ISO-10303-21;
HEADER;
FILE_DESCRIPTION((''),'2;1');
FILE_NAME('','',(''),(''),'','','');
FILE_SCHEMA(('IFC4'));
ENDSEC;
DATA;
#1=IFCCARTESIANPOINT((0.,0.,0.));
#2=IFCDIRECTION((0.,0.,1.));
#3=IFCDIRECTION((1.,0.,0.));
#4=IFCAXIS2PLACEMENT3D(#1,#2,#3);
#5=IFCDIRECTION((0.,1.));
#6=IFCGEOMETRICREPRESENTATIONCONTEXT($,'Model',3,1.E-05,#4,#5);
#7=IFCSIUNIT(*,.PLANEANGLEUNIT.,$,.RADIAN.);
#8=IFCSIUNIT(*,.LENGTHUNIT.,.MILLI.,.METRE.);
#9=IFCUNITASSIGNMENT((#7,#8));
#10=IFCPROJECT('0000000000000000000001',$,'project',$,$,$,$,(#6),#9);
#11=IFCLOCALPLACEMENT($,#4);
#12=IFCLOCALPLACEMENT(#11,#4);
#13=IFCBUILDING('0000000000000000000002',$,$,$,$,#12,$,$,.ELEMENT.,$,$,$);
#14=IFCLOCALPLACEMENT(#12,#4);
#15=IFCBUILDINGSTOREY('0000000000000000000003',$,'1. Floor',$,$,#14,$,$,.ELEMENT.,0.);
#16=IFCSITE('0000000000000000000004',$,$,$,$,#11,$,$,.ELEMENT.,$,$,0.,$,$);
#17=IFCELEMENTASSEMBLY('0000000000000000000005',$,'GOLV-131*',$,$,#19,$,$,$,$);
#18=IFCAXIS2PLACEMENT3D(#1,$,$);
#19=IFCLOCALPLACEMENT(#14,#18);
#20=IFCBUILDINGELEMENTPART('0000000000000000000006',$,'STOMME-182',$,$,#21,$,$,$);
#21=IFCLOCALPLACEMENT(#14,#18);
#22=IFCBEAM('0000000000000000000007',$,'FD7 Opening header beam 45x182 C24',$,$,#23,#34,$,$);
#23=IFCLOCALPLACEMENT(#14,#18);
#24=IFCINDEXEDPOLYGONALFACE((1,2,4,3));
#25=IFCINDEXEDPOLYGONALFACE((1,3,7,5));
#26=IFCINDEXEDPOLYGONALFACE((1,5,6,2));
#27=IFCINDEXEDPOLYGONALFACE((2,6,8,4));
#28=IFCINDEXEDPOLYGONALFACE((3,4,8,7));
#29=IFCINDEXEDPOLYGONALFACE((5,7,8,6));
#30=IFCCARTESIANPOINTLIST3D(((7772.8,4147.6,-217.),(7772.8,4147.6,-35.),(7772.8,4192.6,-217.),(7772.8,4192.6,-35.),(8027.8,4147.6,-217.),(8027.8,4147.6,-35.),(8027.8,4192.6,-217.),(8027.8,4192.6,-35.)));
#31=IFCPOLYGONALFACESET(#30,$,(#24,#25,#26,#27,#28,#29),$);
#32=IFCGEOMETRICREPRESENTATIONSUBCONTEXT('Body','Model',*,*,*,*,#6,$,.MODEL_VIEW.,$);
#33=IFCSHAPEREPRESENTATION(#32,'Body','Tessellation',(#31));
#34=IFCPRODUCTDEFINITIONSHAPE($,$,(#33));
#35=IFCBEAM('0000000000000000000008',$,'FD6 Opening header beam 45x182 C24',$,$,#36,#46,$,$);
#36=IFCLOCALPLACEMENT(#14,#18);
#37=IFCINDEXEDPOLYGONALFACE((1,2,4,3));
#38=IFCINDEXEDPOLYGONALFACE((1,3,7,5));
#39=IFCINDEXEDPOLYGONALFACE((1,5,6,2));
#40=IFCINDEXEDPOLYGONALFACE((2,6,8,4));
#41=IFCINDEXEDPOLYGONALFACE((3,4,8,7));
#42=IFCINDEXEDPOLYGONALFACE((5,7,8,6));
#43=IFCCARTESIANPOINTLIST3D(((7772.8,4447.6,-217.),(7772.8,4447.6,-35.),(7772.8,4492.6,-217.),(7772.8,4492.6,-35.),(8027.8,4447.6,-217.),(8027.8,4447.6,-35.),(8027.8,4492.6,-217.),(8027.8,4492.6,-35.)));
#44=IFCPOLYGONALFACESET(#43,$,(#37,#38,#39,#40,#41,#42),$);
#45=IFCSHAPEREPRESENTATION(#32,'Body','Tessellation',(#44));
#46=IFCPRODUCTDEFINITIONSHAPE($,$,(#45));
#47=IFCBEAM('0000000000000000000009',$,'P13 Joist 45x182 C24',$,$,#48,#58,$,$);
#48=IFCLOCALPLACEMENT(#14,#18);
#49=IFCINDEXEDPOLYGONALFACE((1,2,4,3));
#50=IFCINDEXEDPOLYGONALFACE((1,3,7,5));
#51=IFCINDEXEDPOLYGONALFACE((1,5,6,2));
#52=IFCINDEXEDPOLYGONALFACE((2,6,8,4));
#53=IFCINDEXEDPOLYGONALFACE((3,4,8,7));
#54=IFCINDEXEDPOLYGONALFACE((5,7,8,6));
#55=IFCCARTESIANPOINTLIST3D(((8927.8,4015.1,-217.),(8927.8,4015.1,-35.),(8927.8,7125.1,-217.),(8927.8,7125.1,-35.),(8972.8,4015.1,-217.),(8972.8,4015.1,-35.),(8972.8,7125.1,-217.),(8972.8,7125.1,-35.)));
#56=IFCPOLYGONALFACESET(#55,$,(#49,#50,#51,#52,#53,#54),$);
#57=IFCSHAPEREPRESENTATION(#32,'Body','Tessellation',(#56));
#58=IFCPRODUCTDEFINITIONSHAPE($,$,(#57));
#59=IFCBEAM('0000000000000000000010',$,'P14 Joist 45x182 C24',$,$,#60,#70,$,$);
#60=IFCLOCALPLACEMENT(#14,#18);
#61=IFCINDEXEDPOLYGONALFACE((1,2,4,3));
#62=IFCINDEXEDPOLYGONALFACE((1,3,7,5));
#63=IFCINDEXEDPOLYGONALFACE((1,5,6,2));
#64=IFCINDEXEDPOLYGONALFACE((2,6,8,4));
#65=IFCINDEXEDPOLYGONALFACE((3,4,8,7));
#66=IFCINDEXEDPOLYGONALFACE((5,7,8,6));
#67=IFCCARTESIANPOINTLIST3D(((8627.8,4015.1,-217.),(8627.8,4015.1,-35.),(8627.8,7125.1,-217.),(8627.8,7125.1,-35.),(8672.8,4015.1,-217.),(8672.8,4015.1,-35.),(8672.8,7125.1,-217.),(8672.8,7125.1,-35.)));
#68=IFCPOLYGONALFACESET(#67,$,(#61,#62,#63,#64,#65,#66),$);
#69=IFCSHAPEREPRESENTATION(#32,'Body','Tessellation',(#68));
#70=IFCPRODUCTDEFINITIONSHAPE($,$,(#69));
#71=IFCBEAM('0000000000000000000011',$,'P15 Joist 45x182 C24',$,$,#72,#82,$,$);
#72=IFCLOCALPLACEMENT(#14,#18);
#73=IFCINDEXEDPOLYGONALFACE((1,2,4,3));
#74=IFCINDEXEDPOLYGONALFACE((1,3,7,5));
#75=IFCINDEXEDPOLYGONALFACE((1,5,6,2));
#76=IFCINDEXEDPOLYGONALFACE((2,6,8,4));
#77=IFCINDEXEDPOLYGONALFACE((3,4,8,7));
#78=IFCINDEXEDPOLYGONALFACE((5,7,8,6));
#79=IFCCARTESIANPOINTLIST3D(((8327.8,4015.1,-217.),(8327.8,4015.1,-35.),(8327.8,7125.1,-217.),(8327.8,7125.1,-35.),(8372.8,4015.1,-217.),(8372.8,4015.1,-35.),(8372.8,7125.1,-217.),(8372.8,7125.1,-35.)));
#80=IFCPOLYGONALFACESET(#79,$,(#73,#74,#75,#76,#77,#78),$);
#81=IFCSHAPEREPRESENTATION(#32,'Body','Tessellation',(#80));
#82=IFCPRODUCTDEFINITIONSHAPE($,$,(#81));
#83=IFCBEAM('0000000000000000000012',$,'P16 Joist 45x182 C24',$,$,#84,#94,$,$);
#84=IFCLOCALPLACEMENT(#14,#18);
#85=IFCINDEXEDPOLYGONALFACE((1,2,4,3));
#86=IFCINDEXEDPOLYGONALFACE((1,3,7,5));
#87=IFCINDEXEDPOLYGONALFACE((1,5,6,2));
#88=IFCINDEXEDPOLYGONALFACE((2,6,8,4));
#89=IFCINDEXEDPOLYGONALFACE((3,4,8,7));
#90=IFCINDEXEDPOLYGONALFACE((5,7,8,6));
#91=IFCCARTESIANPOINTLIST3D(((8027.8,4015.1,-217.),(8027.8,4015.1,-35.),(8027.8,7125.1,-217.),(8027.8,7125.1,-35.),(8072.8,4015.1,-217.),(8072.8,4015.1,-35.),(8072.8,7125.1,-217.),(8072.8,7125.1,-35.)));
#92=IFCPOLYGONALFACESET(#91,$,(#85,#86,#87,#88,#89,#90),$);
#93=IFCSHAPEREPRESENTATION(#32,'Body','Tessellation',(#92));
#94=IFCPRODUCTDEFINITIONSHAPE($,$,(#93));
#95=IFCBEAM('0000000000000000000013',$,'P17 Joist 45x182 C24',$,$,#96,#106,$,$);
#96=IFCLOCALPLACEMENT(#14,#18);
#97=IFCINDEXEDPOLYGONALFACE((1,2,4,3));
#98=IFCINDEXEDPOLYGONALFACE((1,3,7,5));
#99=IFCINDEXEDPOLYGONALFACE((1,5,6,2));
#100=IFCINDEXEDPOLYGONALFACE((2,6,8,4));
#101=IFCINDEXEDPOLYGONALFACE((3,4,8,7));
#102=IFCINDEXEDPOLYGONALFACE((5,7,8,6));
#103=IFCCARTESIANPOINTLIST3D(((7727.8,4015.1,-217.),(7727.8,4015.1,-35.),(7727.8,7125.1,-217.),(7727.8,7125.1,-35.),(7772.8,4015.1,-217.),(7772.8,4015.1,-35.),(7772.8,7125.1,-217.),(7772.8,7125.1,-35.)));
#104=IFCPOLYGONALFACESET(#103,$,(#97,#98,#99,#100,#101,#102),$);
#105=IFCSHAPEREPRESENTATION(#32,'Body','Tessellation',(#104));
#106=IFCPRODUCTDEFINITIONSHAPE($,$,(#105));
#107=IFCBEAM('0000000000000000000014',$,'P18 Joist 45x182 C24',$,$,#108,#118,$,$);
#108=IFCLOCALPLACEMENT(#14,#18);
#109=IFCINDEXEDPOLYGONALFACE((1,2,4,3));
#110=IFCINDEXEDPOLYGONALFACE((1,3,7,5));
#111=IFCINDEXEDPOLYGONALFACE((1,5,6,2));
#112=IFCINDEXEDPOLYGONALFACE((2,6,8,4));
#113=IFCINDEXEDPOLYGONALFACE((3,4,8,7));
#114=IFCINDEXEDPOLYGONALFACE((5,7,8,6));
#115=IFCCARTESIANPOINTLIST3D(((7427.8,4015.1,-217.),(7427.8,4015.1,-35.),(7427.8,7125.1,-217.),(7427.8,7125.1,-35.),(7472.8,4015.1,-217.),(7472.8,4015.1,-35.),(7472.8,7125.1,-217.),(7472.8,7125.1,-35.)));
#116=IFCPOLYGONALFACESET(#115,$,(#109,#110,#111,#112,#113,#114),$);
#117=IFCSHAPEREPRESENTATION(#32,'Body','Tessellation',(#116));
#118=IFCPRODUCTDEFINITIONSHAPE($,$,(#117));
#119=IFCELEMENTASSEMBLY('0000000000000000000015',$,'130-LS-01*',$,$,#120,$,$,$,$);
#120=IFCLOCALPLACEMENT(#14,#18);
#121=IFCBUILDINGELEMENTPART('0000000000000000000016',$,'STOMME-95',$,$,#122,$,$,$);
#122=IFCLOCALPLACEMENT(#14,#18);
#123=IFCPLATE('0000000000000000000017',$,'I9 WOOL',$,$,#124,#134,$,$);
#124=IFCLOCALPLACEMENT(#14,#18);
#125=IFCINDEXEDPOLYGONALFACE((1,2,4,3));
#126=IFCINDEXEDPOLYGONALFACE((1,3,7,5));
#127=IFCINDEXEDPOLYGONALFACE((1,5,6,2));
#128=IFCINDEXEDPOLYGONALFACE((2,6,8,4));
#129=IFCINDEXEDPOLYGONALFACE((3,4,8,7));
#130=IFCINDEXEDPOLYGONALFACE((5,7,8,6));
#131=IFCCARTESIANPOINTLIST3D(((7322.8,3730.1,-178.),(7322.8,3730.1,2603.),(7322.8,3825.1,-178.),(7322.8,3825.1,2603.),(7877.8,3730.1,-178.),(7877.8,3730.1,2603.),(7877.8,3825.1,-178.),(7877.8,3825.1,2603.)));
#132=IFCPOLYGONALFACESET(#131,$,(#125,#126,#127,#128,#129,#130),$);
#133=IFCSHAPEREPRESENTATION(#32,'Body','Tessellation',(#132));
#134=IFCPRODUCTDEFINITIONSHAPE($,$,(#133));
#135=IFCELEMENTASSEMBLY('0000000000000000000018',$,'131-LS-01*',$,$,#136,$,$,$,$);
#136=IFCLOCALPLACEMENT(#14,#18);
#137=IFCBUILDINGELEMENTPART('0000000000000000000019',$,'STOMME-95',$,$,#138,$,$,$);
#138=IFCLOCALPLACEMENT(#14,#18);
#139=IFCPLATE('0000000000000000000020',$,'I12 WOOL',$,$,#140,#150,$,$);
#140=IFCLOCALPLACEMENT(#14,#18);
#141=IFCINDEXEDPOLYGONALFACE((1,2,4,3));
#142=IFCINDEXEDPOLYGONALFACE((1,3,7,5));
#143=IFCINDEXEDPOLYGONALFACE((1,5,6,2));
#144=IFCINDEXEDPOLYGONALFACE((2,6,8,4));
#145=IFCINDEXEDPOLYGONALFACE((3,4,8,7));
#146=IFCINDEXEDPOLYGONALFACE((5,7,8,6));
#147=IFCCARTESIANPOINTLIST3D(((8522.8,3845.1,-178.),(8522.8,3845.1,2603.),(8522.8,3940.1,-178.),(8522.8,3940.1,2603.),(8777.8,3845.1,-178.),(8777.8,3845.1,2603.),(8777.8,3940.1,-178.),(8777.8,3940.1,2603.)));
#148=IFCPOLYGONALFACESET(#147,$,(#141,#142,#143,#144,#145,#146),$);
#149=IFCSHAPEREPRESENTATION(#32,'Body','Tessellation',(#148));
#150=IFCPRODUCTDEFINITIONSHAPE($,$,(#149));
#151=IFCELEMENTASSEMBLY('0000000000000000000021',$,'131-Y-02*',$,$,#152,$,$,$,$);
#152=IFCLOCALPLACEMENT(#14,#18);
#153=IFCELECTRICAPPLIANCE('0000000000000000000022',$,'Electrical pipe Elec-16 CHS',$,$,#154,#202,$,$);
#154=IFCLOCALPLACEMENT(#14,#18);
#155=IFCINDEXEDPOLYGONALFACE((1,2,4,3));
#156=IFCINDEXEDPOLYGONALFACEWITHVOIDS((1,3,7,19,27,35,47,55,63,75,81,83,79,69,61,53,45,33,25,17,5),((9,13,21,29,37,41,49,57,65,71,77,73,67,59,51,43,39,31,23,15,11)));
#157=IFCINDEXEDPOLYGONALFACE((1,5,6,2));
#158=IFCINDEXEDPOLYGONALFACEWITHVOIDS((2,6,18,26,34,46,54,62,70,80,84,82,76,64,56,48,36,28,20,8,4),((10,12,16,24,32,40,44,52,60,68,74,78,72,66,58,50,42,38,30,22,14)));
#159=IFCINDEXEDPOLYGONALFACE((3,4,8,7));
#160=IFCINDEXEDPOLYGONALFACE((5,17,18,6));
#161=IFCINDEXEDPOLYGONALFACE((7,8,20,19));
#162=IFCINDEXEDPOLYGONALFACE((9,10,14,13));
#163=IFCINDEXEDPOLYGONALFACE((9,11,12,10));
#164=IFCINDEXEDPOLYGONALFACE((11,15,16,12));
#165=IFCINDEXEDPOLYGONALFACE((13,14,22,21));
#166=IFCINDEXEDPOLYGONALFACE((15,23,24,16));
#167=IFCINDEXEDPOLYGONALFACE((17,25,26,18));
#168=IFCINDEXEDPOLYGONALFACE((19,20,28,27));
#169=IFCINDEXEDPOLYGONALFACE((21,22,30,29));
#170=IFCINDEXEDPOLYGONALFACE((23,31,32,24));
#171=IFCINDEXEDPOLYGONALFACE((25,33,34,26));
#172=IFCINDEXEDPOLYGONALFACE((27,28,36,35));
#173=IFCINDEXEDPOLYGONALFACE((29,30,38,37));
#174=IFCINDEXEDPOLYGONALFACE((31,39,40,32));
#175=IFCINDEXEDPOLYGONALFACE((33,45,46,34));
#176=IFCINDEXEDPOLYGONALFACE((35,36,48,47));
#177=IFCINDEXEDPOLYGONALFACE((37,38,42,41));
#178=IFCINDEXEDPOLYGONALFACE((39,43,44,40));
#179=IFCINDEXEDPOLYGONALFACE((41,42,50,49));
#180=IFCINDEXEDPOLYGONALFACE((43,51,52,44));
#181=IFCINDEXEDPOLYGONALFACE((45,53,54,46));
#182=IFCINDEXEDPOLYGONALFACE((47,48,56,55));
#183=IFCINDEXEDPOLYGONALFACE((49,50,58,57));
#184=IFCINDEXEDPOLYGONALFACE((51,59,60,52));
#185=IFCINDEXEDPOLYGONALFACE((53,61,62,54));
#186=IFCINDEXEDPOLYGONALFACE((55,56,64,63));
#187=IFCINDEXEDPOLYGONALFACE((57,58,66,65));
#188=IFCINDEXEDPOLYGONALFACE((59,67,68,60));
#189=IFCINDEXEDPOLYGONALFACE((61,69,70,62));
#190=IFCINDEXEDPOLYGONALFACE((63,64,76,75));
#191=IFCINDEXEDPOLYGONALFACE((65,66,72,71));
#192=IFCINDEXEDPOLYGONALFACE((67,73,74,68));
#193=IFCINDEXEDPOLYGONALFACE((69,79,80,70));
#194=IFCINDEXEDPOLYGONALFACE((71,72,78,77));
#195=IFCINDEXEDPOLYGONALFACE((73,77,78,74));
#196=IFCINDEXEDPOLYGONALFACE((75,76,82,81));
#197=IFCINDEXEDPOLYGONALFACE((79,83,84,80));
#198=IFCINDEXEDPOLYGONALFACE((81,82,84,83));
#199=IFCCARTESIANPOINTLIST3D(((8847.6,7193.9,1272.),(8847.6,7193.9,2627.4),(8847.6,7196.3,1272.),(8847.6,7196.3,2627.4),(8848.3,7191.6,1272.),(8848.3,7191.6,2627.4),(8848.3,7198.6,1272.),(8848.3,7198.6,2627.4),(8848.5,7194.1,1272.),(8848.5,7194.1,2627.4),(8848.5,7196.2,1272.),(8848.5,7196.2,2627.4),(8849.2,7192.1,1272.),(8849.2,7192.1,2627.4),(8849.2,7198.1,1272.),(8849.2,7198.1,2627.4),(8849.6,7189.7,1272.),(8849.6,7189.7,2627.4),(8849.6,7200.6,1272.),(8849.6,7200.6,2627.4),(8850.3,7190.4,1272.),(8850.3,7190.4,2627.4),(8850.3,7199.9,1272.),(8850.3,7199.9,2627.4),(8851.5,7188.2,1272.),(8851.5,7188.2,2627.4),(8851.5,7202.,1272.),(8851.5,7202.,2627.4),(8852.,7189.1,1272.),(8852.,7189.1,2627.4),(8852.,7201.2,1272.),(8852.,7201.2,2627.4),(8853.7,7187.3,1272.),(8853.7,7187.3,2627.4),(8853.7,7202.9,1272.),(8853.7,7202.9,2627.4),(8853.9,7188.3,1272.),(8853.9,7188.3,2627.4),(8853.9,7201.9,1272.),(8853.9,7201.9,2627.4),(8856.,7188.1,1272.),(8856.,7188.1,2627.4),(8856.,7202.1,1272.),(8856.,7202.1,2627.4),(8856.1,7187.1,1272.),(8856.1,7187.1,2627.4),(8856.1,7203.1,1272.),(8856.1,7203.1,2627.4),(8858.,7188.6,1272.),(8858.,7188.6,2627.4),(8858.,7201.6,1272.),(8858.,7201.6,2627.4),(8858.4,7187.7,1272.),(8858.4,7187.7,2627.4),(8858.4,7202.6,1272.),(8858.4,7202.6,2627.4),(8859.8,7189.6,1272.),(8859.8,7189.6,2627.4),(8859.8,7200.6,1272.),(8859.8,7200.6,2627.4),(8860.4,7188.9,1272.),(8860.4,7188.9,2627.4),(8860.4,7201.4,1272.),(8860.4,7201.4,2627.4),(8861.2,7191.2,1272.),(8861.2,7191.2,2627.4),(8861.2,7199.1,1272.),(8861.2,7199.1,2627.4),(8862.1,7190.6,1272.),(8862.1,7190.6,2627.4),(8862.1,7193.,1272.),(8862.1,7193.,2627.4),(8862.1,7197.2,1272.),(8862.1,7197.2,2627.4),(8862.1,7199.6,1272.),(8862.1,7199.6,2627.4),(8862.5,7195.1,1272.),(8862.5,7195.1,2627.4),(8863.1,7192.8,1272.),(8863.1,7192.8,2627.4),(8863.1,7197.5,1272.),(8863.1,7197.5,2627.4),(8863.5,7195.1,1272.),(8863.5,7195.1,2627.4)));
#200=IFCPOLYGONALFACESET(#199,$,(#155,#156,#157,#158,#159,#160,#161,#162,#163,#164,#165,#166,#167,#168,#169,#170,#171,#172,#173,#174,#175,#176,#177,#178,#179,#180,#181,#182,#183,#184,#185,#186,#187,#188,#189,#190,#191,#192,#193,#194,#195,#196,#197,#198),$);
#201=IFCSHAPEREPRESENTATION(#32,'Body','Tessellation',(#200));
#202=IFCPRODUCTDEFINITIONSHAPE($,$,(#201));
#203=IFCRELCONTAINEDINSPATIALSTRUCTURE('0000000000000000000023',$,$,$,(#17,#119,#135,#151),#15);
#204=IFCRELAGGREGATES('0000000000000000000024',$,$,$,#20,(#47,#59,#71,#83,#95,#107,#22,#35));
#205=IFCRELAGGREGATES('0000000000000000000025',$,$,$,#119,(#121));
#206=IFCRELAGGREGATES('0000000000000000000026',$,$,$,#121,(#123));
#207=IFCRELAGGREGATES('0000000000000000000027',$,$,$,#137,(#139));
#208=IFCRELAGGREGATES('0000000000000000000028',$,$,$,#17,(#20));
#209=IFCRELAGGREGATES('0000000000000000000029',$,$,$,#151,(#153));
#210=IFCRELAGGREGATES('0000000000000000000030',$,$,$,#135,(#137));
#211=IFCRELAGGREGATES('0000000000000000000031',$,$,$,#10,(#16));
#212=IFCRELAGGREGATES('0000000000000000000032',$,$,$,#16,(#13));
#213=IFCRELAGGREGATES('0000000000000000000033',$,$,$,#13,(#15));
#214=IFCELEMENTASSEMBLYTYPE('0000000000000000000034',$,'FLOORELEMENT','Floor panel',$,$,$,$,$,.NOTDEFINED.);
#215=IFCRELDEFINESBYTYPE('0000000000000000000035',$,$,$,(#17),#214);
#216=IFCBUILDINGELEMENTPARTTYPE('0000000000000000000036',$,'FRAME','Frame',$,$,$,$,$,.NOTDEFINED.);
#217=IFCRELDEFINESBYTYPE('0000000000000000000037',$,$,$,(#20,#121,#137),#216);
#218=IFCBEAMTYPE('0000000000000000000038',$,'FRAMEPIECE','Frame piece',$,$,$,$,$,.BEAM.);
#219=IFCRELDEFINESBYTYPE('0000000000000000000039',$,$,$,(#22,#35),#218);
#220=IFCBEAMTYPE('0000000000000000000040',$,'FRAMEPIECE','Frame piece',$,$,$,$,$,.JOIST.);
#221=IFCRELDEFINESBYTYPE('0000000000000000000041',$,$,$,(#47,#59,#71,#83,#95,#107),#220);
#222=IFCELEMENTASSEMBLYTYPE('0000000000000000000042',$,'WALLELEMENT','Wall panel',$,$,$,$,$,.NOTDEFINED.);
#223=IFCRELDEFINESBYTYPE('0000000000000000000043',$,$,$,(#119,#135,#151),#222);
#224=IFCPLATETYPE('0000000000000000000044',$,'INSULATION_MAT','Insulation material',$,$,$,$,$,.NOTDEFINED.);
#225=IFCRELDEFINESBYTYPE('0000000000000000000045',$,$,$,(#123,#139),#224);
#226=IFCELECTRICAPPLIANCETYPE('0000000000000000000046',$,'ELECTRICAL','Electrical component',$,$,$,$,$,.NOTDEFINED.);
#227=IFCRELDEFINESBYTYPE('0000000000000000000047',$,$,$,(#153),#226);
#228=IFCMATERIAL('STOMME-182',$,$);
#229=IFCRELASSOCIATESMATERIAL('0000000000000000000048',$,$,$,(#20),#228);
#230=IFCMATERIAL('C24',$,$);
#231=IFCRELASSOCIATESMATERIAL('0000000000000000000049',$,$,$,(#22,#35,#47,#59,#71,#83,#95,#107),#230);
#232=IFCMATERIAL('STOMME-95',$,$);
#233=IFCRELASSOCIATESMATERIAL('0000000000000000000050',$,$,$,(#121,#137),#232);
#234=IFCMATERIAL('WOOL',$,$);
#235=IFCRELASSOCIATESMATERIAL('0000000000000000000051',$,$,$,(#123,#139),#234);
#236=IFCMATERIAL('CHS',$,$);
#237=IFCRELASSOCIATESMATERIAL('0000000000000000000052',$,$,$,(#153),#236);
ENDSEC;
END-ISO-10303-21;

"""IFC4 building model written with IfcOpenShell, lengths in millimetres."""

from ifc_helpers import new_model, si_unit, direction, frame, origin_with_axes, origin_2d_with_axis, place, context, subcontext, project, spatial, rectangle, hollow_circle, extrude, material, type_object, element, aggregate, save


model = new_model("IFC4")

# Units and contexts
model_context = context("Model", 3, precision=1e-05, world=origin_with_axes(), true_north=direction((0.0, 1.0)))
body_context = subcontext(model_context, "Body", "Model", "MODEL_VIEW")
ifc_project = project(units=[si_unit("PLANEANGLEUNIT", "RADIAN"), si_unit("LENGTHUNIT", "METRE", prefix="MILLI")], contexts=[model_context])

# Site, building, storey
site_placement = place(None, origin_with_axes())
site = spatial("IfcSite", under=ifc_project, at=site_placement, CompositionType="ELEMENT", RefElevation=0.0)
building_placement = place(site_placement, origin_with_axes())
building = spatial("IfcBuilding", under=site, at=building_placement, CompositionType="ELEMENT")
storey_placement = place(building_placement, origin_with_axes())
storey = spatial("IfcBuildingStorey", under=building, at=storey_placement, Name="1. Floor", CompositionType="ELEMENT", Elevation=0.0)

# Element assembly, building element part, beams
element_assembly_type_1 = type_object("IfcElementAssemblyType", Name="FLOORELEMENT", Description="Floor panel", PredefinedType="NOTDEFINED")
assembly_1_placement = place(storey_placement, origin_with_axes())
assembly_1 = element("IfcElementAssembly", 1, at=assembly_1_placement, inside=storey, type_object=element_assembly_type_1, Name="GOLV-131*")
ifc_material_1 = material(Name="STOMME-182")
building_element_part_type_1 = type_object("IfcBuildingElementPartType", Name="FRAME", Description="Frame", PredefinedType="NOTDEFINED")
building_element_part_1_placement = place(storey_placement, origin_with_axes())
building_element_part_1 = element("IfcBuildingElementPart", 2, at=building_element_part_1_placement, type_object=building_element_part_type_1, material=ifc_material_1, Name="STOMME-182")
ifc_material_2 = material(Name="C24")
beam_type_1 = type_object("IfcBeamType", Name="FRAMEPIECE", Description="Frame piece", PredefinedType="BEAM")
beam_1_placement = place(storey_placement, frame((7772.8, 4170.1, -126.0), z_axis=(1.0, 0.0, 0.0), x_axis=(0.0, 1.0, 0.0)))
beam_1 = element("IfcBeam", 3, at=beam_1_placement, type_object=beam_type_1, material=ifc_material_2, Name="FD7 Opening header beam 45x182 C24", context=body_context, shape_type="SweptSolid", body=[
    extrude(rectangle(XDim=45.0, YDim=182.0, at=origin_2d_with_axis()), origin_with_axes(), (0.0, 0.0, 1.0), 255.0),
])
beam_2_placement = place(storey_placement, frame((8027.8, 4470.1, -126.0), z_axis=(-1.0, 0.0, 0.0), x_axis=(0.0, -1.0, 0.0)))
beam_2 = element("IfcBeam", 4, at=beam_2_placement, type_object=beam_type_1, material=ifc_material_2, Name="FD6 Opening header beam 45x182 C24", context=body_context, shape_type="SweptSolid", body=[
    extrude(rectangle(XDim=45.0, YDim=182.0, at=origin_2d_with_axis()), origin_with_axes(), (0.0, 0.0, 1.0), 255.0),
])
beam_type_2 = type_object("IfcBeamType", Name="FRAMEPIECE", Description="Frame piece", PredefinedType="JOIST")
beam_3_placement = place(storey_placement, frame((8950.3, 4015.1, -126.0), z_axis=(0.0, 1.0, 0.0), x_axis=(-1.0, 0.0, 0.0)))
beam_3 = element("IfcBeam", 5, at=beam_3_placement, type_object=beam_type_2, material=ifc_material_2, Name="P13 Joist 45x182 C24", context=body_context, shape_type="SweptSolid", body=[
    extrude(rectangle(XDim=45.0, YDim=182.0, at=origin_2d_with_axis()), origin_with_axes(), (0.0, 0.0, 1.0), 3110.0),
])
beam_4_placement = place(storey_placement, frame((8650.3, 4015.1, -126.0), z_axis=(0.0, 1.0, 0.0), x_axis=(-1.0, 0.0, 0.0)))
beam_4 = element("IfcBeam", 6, at=beam_4_placement, type_object=beam_type_2, material=ifc_material_2, Name="P14 Joist 45x182 C24", context=body_context, shape_type="SweptSolid", body=[
    extrude(rectangle(XDim=45.0, YDim=182.0, at=origin_2d_with_axis()), origin_with_axes(), (0.0, 0.0, 1.0), 3110.0),
])
beam_5_placement = place(storey_placement, frame((8350.3, 4015.1, -126.0), z_axis=(0.0, 1.0, 0.0), x_axis=(-1.0, 0.0, 0.0)))
beam_5 = element("IfcBeam", 7, at=beam_5_placement, type_object=beam_type_2, material=ifc_material_2, Name="P15 Joist 45x182 C24", context=body_context, shape_type="SweptSolid", body=[
    extrude(rectangle(XDim=45.0, YDim=182.0, at=origin_2d_with_axis()), origin_with_axes(), (0.0, 0.0, 1.0), 3110.0),
])
beam_6_placement = place(storey_placement, frame((8050.3, 4015.1, -126.0), z_axis=(0.0, 1.0, 0.0), x_axis=(-1.0, 0.0, 0.0)))
beam_6 = element("IfcBeam", 8, at=beam_6_placement, type_object=beam_type_2, material=ifc_material_2, Name="P16 Joist 45x182 C24", context=body_context, shape_type="SweptSolid", body=[
    extrude(rectangle(XDim=45.0, YDim=182.0, at=origin_2d_with_axis()), origin_with_axes(), (0.0, 0.0, 1.0), 3110.0),
])
beam_7_placement = place(storey_placement, frame((7750.3, 4015.1, -126.0), z_axis=(0.0, 1.0, 0.0), x_axis=(-1.0, 0.0, 0.0)))
beam_7 = element("IfcBeam", 9, at=beam_7_placement, type_object=beam_type_2, material=ifc_material_2, Name="P17 Joist 45x182 C24", context=body_context, shape_type="SweptSolid", body=[
    extrude(rectangle(XDim=45.0, YDim=182.0, at=origin_2d_with_axis()), origin_with_axes(), (0.0, 0.0, 1.0), 3110.0),
])
beam_8_placement = place(storey_placement, frame((7450.3, 4015.1, -126.0), z_axis=(0.0, 1.0, 0.0), x_axis=(-1.0, 0.0, 0.0)))
beam_8 = element("IfcBeam", 10, at=beam_8_placement, type_object=beam_type_2, material=ifc_material_2, Name="P18 Joist 45x182 C24", context=body_context, shape_type="SweptSolid", body=[
    extrude(rectangle(XDim=45.0, YDim=182.0, at=origin_2d_with_axis()), origin_with_axes(), (0.0, 0.0, 1.0), 3110.0),
])
plate_type_1 = type_object("IfcPlateType", Name="INSULATION_MAT", Description="Insulation material", PredefinedType="NOTDEFINED")
aggregate(building_element_part_1, [beam_3, beam_4, beam_5, beam_6, beam_7, beam_8, beam_1, beam_2])

# Element assemblies, building element parts, plates
element_assembly_type_2 = type_object("IfcElementAssemblyType", Name="WALLELEMENT", Description="Wall panel", PredefinedType="NOTDEFINED")
assembly_2_placement = place(storey_placement, origin_with_axes())
assembly_2 = element("IfcElementAssembly", 11, at=assembly_2_placement, inside=storey, type_object=element_assembly_type_2, Name="130-LS-01*")
ifc_material_3 = material(Name="STOMME-95")
building_element_part_2_placement = place(storey_placement, origin_with_axes())
building_element_part_2 = element("IfcBuildingElementPart", 12, at=building_element_part_2_placement, type_object=building_element_part_type_1, material=ifc_material_3, Name="STOMME-95")
aggregate(assembly_2, [building_element_part_2])
ifc_material_4 = material(Name="WOOL")
plate_1_placement = place(storey_placement, frame((7600.3, 3825.1, 1212.5), z_axis=(0.0, 1.0, 0.0), x_axis=(-1.0, 0.0, 0.0)))
plate_1 = element("IfcPlate", 13, at=plate_1_placement, type_object=plate_type_1, material=ifc_material_4, Name="I9 WOOL", context=body_context, shape_type="SweptSolid", body=[
    extrude(rectangle(XDim=95.0, YDim=555.0, at=origin_2d_with_axis()), frame((0.0, -1390.5, -47.5), z_axis=(0.0, 1.0, 0.0), x_axis=(0.0, 0.0, 1.0)), (0.0, 0.0, 1.0), 2781.0),
])
aggregate(building_element_part_2, [plate_1])
assembly_3_placement = place(storey_placement, origin_with_axes())
assembly_3 = element("IfcElementAssembly", 14, at=assembly_3_placement, inside=storey, type_object=element_assembly_type_2, Name="131-LS-01*")
building_element_part_3_placement = place(storey_placement, origin_with_axes())
building_element_part_3 = element("IfcBuildingElementPart", 15, at=building_element_part_3_placement, type_object=building_element_part_type_1, material=ifc_material_3, Name="STOMME-95")
plate_2_placement = place(storey_placement, frame((8650.3, 3845.1, 1212.5), z_axis=(0.0, -1.0, 0.0), x_axis=(1.0, 0.0, 0.0)))
plate_2 = element("IfcPlate", 16, at=plate_2_placement, type_object=plate_type_1, material=ifc_material_4, Name="I12 WOOL", context=body_context, shape_type="SweptSolid", body=[
    extrude(rectangle(XDim=95.0, YDim=255.0, at=origin_2d_with_axis()), frame((0.0, -1390.5, -47.5), z_axis=(0.0, 1.0, 0.0), x_axis=(0.0, 0.0, 1.0)), (0.0, 0.0, 1.0), 2781.0),
])
aggregate(building_element_part_3, [plate_2])

aggregate(assembly_1, [building_element_part_1])

# Element assembly, electric appliance
assembly_4_placement = place(storey_placement, origin_with_axes())
assembly_4 = element("IfcElementAssembly", 17, at=assembly_4_placement, inside=storey, type_object=element_assembly_type_2, Name="131-Y-02*")
ifc_material_5 = material(Name="CHS")
electric_appliance_type = type_object("IfcElectricApplianceType", Name="ELECTRICAL", Description="Electrical component", PredefinedType="NOTDEFINED")
electric_appliance_1_placement = place(storey_placement, frame((8855.5, 7195.1, 1272.0), z_axis=(0.0, 0.0, 1.0), x_axis=(1.0, 0.0, 0.0)))
electric_appliance_1 = element("IfcElectricAppliance", 18, at=electric_appliance_1_placement, type_object=electric_appliance_type, material=ifc_material_5, Name="Electrical pipe Elec-16 CHS", context=body_context, shape_type="SweptSolid", body=[
    extrude(hollow_circle(Radius=8.0, WallThickness=1.0, at=origin_2d_with_axis()), origin_with_axes(), (0.0, 0.0, 1.0), 1355.4),
])
aggregate(assembly_4, [electric_appliance_1])

aggregate(assembly_3, [building_element_part_3])

save(model, "model.ifc")
